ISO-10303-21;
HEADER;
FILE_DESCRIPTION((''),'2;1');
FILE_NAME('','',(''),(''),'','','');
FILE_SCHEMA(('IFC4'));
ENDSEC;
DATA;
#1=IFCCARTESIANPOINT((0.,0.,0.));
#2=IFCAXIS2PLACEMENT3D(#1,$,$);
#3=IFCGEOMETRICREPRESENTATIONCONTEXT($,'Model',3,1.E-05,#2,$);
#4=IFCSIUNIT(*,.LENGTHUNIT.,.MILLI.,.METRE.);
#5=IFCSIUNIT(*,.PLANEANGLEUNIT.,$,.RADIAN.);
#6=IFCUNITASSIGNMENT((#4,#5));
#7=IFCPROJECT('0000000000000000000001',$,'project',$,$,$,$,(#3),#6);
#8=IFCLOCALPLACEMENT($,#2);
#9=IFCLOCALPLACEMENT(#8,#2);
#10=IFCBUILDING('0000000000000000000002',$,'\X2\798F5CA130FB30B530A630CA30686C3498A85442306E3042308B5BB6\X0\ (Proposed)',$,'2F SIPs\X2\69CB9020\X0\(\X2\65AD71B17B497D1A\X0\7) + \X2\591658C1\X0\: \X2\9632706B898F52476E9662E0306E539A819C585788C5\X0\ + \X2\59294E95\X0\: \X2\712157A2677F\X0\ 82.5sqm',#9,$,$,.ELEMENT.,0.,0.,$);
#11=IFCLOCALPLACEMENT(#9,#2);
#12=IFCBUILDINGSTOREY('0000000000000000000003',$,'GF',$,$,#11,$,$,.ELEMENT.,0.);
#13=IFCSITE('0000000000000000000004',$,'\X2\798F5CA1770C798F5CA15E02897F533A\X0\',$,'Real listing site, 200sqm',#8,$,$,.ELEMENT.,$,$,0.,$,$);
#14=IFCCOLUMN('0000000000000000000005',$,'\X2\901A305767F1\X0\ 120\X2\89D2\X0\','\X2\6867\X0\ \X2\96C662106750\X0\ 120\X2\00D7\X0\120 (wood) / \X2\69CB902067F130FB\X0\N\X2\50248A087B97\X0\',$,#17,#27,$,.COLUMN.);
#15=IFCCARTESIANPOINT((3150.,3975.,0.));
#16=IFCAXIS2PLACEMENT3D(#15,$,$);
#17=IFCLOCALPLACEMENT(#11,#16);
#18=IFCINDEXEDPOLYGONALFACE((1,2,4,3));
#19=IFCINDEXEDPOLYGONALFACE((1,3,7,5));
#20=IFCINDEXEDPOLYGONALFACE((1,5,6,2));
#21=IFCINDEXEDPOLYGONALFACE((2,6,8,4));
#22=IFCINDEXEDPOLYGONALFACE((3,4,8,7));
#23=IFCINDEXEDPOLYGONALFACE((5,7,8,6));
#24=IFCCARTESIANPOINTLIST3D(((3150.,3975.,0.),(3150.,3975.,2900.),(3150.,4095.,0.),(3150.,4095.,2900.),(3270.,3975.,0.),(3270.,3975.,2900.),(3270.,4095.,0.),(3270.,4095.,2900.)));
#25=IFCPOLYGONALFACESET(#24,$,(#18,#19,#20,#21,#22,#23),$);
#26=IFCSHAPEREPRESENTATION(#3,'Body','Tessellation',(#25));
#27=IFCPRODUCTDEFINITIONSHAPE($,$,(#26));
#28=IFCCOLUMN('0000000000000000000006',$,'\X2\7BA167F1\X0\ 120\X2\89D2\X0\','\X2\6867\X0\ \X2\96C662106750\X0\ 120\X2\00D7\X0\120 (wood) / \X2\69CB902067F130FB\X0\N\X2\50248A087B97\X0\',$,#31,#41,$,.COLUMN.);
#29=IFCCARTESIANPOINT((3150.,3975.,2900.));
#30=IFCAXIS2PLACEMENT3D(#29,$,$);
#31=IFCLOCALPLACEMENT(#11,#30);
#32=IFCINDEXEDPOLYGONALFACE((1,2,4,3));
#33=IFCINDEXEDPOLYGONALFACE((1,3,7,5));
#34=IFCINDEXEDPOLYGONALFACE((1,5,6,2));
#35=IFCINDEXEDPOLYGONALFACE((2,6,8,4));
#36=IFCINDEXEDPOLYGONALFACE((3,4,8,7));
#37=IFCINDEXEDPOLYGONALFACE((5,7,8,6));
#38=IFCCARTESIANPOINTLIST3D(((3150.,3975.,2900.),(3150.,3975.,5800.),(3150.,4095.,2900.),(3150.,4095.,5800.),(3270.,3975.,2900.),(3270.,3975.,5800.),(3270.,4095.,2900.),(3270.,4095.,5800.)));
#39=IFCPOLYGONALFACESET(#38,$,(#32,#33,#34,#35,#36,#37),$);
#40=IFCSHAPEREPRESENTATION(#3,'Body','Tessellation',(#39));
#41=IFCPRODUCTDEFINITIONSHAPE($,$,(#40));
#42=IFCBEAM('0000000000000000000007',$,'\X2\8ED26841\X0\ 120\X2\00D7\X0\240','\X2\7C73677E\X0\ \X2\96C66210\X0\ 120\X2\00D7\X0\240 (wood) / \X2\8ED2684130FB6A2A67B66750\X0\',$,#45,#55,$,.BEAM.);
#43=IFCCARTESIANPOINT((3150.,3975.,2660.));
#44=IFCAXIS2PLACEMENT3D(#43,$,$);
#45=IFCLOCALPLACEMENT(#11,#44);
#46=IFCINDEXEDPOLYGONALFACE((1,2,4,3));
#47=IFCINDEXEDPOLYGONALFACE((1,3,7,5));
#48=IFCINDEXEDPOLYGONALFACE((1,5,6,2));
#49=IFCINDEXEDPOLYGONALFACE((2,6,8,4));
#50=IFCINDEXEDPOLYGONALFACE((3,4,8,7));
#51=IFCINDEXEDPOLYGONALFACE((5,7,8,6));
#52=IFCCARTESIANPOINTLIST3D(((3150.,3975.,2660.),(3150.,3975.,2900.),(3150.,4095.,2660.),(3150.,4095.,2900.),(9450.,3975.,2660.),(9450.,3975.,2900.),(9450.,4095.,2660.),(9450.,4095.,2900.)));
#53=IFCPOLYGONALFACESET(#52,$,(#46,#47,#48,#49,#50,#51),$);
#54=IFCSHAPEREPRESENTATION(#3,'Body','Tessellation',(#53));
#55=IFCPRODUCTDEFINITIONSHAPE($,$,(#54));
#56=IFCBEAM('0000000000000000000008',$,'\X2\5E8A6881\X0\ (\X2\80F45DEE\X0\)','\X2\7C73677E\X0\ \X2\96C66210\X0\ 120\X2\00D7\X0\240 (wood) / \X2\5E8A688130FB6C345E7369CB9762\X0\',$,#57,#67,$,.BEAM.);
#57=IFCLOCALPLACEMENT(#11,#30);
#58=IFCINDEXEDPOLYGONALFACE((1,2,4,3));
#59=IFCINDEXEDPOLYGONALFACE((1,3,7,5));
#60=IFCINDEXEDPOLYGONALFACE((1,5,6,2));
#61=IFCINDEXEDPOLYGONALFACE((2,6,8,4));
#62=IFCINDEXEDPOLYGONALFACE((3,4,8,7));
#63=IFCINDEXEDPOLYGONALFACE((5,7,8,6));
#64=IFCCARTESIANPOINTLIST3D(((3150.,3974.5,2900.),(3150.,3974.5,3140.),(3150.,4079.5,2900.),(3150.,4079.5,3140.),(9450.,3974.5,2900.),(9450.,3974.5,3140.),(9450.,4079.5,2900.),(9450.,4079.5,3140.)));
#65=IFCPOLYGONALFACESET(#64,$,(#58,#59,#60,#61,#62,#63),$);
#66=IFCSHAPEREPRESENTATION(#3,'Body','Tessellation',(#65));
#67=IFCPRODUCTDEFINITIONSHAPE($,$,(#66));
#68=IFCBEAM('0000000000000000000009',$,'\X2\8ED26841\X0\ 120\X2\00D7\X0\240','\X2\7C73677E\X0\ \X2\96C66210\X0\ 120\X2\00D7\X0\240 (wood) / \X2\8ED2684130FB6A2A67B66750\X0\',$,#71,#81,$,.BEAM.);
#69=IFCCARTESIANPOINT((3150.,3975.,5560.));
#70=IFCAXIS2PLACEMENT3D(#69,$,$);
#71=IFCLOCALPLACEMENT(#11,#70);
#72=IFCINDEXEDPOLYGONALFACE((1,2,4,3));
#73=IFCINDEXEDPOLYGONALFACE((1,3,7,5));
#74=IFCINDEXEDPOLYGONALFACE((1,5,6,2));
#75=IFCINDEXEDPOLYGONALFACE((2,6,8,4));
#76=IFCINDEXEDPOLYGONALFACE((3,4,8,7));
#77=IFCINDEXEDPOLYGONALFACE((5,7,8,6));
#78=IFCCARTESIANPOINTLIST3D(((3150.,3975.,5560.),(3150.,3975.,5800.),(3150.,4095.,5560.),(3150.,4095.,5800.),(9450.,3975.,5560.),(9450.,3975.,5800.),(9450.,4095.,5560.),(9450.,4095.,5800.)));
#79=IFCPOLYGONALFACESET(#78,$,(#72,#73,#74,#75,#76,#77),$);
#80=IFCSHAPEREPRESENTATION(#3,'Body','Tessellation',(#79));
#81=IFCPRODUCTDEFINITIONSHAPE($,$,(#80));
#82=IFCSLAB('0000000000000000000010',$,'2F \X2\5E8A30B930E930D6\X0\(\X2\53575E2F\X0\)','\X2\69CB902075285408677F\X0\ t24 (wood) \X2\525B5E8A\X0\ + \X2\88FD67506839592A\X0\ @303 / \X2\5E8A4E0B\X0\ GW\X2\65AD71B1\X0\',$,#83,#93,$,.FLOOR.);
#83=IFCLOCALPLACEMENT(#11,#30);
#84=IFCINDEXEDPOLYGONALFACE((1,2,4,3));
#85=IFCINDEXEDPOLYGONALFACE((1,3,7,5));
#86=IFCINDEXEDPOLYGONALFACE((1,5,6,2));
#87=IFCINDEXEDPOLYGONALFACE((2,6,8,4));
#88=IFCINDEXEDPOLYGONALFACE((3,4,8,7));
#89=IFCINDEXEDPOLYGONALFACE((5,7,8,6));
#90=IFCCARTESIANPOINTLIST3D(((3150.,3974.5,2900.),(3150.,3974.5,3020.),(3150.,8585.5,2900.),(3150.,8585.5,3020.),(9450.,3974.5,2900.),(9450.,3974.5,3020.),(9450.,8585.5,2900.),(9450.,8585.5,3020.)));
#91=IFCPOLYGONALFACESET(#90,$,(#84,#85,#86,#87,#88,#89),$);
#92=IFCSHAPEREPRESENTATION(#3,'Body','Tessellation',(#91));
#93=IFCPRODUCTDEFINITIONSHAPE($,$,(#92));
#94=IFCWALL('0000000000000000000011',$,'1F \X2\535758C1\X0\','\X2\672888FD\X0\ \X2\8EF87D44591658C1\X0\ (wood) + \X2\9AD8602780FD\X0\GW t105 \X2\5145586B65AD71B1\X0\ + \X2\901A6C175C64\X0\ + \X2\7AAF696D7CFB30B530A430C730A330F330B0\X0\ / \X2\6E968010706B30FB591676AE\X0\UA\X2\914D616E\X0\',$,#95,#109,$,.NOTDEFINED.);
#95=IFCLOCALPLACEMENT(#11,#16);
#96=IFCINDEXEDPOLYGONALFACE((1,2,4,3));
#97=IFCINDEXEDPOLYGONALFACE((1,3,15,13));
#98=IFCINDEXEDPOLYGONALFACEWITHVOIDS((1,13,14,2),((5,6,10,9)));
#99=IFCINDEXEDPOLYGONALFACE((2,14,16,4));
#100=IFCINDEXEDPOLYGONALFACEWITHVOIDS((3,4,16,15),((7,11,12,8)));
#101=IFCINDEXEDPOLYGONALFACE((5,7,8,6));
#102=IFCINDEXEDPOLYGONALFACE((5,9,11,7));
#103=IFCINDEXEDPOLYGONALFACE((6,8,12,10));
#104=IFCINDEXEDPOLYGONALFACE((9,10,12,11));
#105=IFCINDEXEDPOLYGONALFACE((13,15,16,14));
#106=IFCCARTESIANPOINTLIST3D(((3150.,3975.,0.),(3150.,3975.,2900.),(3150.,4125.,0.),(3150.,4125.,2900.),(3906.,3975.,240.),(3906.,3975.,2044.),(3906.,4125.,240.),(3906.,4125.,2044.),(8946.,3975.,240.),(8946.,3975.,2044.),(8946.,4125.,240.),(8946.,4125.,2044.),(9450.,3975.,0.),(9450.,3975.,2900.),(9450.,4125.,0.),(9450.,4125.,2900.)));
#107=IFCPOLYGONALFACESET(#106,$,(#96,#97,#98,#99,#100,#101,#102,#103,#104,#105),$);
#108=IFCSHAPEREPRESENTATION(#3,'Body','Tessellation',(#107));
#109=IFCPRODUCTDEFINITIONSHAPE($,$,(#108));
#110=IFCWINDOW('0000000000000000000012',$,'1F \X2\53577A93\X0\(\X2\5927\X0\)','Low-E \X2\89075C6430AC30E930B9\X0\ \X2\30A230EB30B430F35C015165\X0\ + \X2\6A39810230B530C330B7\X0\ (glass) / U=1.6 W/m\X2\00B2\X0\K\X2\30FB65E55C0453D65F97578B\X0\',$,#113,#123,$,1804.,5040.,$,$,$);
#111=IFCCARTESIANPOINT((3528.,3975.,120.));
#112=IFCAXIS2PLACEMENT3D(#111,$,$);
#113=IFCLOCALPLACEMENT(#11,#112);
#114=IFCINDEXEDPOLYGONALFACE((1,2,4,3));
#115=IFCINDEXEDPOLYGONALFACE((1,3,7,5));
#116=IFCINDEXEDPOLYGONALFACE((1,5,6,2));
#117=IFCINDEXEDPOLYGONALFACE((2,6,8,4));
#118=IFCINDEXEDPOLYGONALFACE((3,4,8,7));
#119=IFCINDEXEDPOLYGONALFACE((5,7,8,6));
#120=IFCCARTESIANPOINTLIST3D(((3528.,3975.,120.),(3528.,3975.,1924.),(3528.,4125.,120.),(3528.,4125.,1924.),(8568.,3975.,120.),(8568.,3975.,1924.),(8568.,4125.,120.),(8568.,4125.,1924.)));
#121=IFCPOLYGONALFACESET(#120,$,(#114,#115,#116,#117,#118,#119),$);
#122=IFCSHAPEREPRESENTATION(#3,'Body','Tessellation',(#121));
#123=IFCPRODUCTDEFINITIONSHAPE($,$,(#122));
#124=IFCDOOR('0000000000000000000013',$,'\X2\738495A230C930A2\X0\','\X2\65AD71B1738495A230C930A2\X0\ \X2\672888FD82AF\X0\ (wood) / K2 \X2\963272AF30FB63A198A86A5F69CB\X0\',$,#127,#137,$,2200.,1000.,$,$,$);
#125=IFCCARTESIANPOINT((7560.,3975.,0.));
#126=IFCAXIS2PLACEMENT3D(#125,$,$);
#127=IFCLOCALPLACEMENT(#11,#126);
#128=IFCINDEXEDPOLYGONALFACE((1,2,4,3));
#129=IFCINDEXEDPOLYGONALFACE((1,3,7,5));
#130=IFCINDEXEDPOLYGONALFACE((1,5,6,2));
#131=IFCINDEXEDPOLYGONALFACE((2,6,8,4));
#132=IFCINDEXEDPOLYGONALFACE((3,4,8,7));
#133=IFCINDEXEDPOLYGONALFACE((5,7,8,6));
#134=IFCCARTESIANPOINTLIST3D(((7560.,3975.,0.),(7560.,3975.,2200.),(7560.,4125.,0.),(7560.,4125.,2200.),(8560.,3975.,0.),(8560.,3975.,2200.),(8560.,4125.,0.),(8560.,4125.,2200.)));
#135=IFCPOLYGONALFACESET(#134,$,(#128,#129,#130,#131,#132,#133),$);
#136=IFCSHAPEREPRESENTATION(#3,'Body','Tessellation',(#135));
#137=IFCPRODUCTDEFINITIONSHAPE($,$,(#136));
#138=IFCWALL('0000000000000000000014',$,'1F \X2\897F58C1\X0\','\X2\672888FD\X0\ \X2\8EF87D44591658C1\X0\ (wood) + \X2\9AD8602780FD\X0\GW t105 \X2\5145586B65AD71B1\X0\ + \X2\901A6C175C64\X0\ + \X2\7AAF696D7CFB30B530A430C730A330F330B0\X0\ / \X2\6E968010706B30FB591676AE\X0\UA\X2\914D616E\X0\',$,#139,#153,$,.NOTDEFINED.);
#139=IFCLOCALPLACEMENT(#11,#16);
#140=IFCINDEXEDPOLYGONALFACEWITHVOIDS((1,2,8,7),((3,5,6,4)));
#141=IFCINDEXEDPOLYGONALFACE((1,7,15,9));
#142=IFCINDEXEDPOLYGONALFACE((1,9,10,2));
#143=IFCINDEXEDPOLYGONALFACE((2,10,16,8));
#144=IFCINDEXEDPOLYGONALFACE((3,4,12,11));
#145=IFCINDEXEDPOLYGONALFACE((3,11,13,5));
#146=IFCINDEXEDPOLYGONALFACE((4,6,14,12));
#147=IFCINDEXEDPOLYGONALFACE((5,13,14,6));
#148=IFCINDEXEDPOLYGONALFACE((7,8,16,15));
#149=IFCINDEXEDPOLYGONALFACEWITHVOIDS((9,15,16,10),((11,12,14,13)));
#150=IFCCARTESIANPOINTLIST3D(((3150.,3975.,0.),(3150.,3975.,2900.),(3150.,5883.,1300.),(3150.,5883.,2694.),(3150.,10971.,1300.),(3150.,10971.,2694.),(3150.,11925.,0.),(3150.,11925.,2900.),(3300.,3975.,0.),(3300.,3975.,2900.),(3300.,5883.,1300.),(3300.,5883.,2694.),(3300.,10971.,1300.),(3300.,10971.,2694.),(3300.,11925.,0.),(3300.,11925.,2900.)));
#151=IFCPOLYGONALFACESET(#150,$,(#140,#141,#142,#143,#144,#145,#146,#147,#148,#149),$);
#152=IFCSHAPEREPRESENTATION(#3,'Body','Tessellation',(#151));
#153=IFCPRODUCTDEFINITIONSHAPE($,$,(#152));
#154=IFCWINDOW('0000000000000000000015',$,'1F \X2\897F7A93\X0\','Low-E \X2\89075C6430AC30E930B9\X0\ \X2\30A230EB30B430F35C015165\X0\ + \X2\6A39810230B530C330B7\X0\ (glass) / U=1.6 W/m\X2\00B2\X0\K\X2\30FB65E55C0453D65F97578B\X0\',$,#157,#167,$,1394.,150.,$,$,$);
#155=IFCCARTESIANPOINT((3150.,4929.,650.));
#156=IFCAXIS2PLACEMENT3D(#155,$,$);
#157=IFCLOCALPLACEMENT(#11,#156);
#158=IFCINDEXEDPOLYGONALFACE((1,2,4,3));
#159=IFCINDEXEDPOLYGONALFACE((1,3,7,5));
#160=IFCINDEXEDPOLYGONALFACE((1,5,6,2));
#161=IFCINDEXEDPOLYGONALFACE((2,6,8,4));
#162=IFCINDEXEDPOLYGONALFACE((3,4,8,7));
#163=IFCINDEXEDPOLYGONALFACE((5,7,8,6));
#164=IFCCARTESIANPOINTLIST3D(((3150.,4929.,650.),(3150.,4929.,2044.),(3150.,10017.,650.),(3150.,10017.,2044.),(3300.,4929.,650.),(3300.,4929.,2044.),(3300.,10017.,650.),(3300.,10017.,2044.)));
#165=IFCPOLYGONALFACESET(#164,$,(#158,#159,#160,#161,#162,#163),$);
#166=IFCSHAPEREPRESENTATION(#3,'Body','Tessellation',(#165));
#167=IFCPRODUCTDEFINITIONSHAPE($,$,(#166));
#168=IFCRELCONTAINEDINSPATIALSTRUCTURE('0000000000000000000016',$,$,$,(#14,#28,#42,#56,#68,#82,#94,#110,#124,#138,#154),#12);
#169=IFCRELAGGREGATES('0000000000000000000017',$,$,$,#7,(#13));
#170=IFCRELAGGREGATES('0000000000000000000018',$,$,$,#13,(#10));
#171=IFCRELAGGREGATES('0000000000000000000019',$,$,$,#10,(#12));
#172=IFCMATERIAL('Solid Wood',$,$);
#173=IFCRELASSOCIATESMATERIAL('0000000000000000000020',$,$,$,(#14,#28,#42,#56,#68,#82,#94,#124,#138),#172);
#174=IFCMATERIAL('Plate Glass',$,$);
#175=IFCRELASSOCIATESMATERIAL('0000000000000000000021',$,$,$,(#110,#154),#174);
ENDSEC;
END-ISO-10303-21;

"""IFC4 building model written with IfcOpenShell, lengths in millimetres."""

from ifc_helpers import new_model, si_unit, frame, frame_2d, origin, place, context, project, spatial, rectangle, extrude, material, element, fill, save


model = new_model("IFC4")

# Units and contexts
model_context = context("Model", 3, precision=1e-05, world=origin())
ifc_project = project(units=[si_unit("LENGTHUNIT", "METRE", prefix="MILLI"), si_unit("PLANEANGLEUNIT", "RADIAN")], contexts=[model_context])

# Site, building, storey
site_placement = place(None, origin())
site = spatial("IfcSite", under=ifc_project, at=site_placement, Name="福岡県福岡市西区", ObjectType="Real listing site, 200sqm", CompositionType="ELEMENT", RefElevation=0.0)
building_placement = place(site_placement, origin())
building = spatial("IfcBuilding", under=site, at=building_placement, Name="福岡・サウナと水風呂のある家 (Proposed)", ObjectType="2F SIPs構造(断熱等級7) + 外壁: 防火規則準拠の厚膜塗装 + 天井: 無垢板 82.5sqm", CompositionType="ELEMENT", ElevationOfRefHeight=0.0, ElevationOfTerrain=0.0)
storey_placement = place(building_placement, origin())
storey = spatial("IfcBuildingStorey", under=building, at=storey_placement, Name="GF", CompositionType="ELEMENT", Elevation=0.0)

# Columns
ifc_material_1 = material(Name="Solid Wood")
column_1_placement = place(storey_placement, frame((3150.0, 3975.0, 0.0)))
element("IfcColumn", 1, at=column_1_placement, inside=storey, material=ifc_material_1, Name="通し柱 120角", Description="桧 集成材 120×120 (wood) / 構造柱・N値計算", PredefinedType="COLUMN", context=model_context, shape_type="SweptSolid", body=[
    extrude(rectangle(XDim=120.0, YDim=120.0, at=frame_2d((60.0, 60.0))), frame((3150.0, 3975.0, 0.0)), (0.0, 0.0, 1.0), 2900.0),
])
column_2_placement = place(storey_placement, frame((3150.0, 3975.0, 2900.0)))
element("IfcColumn", 2, at=column_2_placement, inside=storey, material=ifc_material_1, Name="管柱 120角", Description="桧 集成材 120×120 (wood) / 構造柱・N値計算", PredefinedType="COLUMN", context=model_context, shape_type="SweptSolid", body=[
    extrude(rectangle(XDim=120.0, YDim=120.0, at=frame_2d((60.0, 60.0))), frame((3150.0, 3975.0, 2900.0)), (0.0, 0.0, 1.0), 2900.0),
])

# Beams
beam_1_placement = place(storey_placement, frame((3150.0, 3975.0, 2660.0)))
element("IfcBeam", 3, at=beam_1_placement, inside=storey, material=ifc_material_1, Name="軒桁 120×240", Description="米松 集成 120×240 (wood) / 軒桁・横架材", PredefinedType="BEAM", context=model_context, shape_type="SweptSolid", body=[
    extrude(rectangle(XDim=6300.0, YDim=120.0, at=frame_2d((3150.0, 60.0))), frame((3150.0, 3975.0, 2660.0)), (0.0, 0.0, 1.0), 240.0),
])
beam_2_placement = place(storey_placement, frame((3150.0, 3975.0, 2900.0)))
element("IfcBeam", 4, at=beam_2_placement, inside=storey, material=ifc_material_1, Name="床梁 (胴差)", Description="米松 集成 120×240 (wood) / 床梁・水平構面", PredefinedType="BEAM", context=model_context, shape_type="SweptSolid", body=[
    extrude(rectangle(XDim=6300.0, YDim=105.0, at=frame_2d((3150.0, 52.0))), frame((3150.0, 3975.0, 2900.0)), (0.0, 0.0, 1.0), 240.0),
])
beam_3_placement = place(storey_placement, frame((3150.0, 3975.0, 5560.0)))
element("IfcBeam", 5, at=beam_3_placement, inside=storey, material=ifc_material_1, Name="軒桁 120×240", Description="米松 集成 120×240 (wood) / 軒桁・横架材", PredefinedType="BEAM", context=model_context, shape_type="SweptSolid", body=[
    extrude(rectangle(XDim=6300.0, YDim=120.0, at=frame_2d((3150.0, 60.0))), frame((3150.0, 3975.0, 5560.0)), (0.0, 0.0, 1.0), 240.0),
])

# Slab
slab_1_placement = place(storey_placement, frame((3150.0, 3975.0, 2900.0)))
element("IfcSlab", 6, at=slab_1_placement, inside=storey, material=ifc_material_1, Name="2F 床スラブ(南帯)", Description="構造用合板 t24 (wood) 剛床 + 製材根太 @303 / 床下 GW断熱", PredefinedType="FLOOR", context=model_context, shape_type="SweptSolid", body=[
    extrude(rectangle(XDim=6300.0, YDim=4611.0, at=frame_2d((3150.0, 2305.0))), frame((3150.0, 3975.0, 2900.0)), (0.0, 0.0, 1.0), 120.0),
])

# Wall, openings, window, door
wall_1_placement = place(storey_placement, frame((3150.0, 3975.0, 0.0)))
wall_1 = element("IfcWall", 7, at=wall_1_placement, inside=storey, material=ifc_material_1, Name="1F 南壁", Description="木製 軸組外壁 (wood) + 高性能GW t105 充填断熱 + 通気層 + 窯業系サイディング / 準耐火・外皮UA配慮", PredefinedType="NOTDEFINED", context=model_context, shape_type="SweptSolid", body=[
    extrude(rectangle(XDim=6300.0, YDim=150.0, at=frame_2d((3150.0, 75.0))), frame((3150.0, 3975.0, 0.0)), (0.0, 0.0, 1.0), 2900.0),
])
opening_1_placement = place(storey_placement, frame((3528.0, 3975.0, 120.0)))
opening_1 = element("IfcOpeningElement", 8, at=opening_1_placement, cuts=wall_1, PredefinedType="NOTDEFINED", context=model_context, shape_type="SweptSolid", body=[
    extrude(rectangle(XDim=5040.0, YDim=150.0, at=frame_2d((2520.0, 75.0))), frame((3528.0, 3975.0, 120.0)), (0.0, 0.0, 1.0), 1804.0),
])
opening_2_placement = place(storey_placement, frame((7560.0, 3975.0, 0.0)))
opening_2 = element("IfcOpeningElement", 9, at=opening_2_placement, cuts=wall_1, PredefinedType="NOTDEFINED", context=model_context, shape_type="SweptSolid", body=[
    extrude(rectangle(XDim=1000.0, YDim=150.0, at=frame_2d((500.0, 75.0))), frame((7560.0, 3975.0, 0.0)), (0.0, 0.0, 1.0), 2200.0),
])
ifc_material_2 = material(Name="Plate Glass")
window_1_placement = place(storey_placement, frame((3528.0, 3975.0, 120.0)))
window_1 = element("IfcWindow", 10, at=window_1_placement, inside=storey, material=ifc_material_2, Name="1F 南窓(大)", Description="Low-E 複層ガラス アルゴン封入 + 樹脂サッシ (glass) / U=1.6 W/m²K・日射取得型", OverallHeight=1804.0, OverallWidth=5040.0, context=model_context, shape_type="SweptSolid", body=[
    extrude(rectangle(XDim=5040.0, YDim=150.0, at=frame_2d((2520.0, 75.0))), frame((3528.0, 3975.0, 120.0)), (0.0, 0.0, 1.0), 1804.0),
])
fill(opening_1, window_1)
door_placement = place(storey_placement, frame((7560.0, 3975.0, 0.0)))
door = element("IfcDoor", 11, at=door_placement, inside=storey, material=ifc_material_1, Name="玄関ドア", Description="断熱玄関ドア 木製芯 (wood) / K2 防犯・採風機構", OverallHeight=2200.0, OverallWidth=1000.0, context=model_context, shape_type="SweptSolid", body=[
    extrude(rectangle(XDim=1000.0, YDim=150.0, at=frame_2d((500.0, 75.0))), frame((7560.0, 3975.0, 0.0)), (0.0, 0.0, 1.0), 2200.0),
])
fill(opening_2, door)

# Wall, opening, window
wall_2_placement = place(storey_placement, frame((3150.0, 3975.0, 0.0)))
wall_2 = element("IfcWall", 12, at=wall_2_placement, inside=storey, material=ifc_material_1, Name="1F 西壁", Description="木製 軸組外壁 (wood) + 高性能GW t105 充填断熱 + 通気層 + 窯業系サイディング / 準耐火・外皮UA配慮", PredefinedType="NOTDEFINED", context=model_context, shape_type="SweptSolid", body=[
    extrude(rectangle(XDim=150.0, YDim=7950.0, at=frame_2d((75.0, 3975.0))), frame((3150.0, 3975.0, 0.0)), (0.0, 0.0, 1.0), 2900.0),
])
opening_3_placement = place(storey_placement, frame((3150.0, 4929.0, 650.0)))
opening_3 = element("IfcOpeningElement", 13, at=opening_3_placement, cuts=wall_2, PredefinedType="NOTDEFINED", context=model_context, shape_type="SweptSolid", body=[
    extrude(rectangle(XDim=150.0, YDim=5088.0, at=frame_2d((75.0, 2544.0))), frame((3150.0, 4929.0, 650.0)), (0.0, 0.0, 1.0), 1394.0),
])
window_2_placement = place(storey_placement, frame((3150.0, 4929.0, 650.0)))
window_2 = element("IfcWindow", 14, at=window_2_placement, inside=storey, material=ifc_material_2, Name="1F 西窓", Description="Low-E 複層ガラス アルゴン封入 + 樹脂サッシ (glass) / U=1.6 W/m²K・日射取得型", OverallHeight=1394.0, OverallWidth=150.0, context=model_context, shape_type="SweptSolid", body=[
    extrude(rectangle(XDim=150.0, YDim=5088.0, at=frame_2d((75.0, 2544.0))), frame((3150.0, 4929.0, 650.0)), (0.0, 0.0, 1.0), 1394.0),
])
fill(opening_3, window_2)

save(model, "model.ifc")
